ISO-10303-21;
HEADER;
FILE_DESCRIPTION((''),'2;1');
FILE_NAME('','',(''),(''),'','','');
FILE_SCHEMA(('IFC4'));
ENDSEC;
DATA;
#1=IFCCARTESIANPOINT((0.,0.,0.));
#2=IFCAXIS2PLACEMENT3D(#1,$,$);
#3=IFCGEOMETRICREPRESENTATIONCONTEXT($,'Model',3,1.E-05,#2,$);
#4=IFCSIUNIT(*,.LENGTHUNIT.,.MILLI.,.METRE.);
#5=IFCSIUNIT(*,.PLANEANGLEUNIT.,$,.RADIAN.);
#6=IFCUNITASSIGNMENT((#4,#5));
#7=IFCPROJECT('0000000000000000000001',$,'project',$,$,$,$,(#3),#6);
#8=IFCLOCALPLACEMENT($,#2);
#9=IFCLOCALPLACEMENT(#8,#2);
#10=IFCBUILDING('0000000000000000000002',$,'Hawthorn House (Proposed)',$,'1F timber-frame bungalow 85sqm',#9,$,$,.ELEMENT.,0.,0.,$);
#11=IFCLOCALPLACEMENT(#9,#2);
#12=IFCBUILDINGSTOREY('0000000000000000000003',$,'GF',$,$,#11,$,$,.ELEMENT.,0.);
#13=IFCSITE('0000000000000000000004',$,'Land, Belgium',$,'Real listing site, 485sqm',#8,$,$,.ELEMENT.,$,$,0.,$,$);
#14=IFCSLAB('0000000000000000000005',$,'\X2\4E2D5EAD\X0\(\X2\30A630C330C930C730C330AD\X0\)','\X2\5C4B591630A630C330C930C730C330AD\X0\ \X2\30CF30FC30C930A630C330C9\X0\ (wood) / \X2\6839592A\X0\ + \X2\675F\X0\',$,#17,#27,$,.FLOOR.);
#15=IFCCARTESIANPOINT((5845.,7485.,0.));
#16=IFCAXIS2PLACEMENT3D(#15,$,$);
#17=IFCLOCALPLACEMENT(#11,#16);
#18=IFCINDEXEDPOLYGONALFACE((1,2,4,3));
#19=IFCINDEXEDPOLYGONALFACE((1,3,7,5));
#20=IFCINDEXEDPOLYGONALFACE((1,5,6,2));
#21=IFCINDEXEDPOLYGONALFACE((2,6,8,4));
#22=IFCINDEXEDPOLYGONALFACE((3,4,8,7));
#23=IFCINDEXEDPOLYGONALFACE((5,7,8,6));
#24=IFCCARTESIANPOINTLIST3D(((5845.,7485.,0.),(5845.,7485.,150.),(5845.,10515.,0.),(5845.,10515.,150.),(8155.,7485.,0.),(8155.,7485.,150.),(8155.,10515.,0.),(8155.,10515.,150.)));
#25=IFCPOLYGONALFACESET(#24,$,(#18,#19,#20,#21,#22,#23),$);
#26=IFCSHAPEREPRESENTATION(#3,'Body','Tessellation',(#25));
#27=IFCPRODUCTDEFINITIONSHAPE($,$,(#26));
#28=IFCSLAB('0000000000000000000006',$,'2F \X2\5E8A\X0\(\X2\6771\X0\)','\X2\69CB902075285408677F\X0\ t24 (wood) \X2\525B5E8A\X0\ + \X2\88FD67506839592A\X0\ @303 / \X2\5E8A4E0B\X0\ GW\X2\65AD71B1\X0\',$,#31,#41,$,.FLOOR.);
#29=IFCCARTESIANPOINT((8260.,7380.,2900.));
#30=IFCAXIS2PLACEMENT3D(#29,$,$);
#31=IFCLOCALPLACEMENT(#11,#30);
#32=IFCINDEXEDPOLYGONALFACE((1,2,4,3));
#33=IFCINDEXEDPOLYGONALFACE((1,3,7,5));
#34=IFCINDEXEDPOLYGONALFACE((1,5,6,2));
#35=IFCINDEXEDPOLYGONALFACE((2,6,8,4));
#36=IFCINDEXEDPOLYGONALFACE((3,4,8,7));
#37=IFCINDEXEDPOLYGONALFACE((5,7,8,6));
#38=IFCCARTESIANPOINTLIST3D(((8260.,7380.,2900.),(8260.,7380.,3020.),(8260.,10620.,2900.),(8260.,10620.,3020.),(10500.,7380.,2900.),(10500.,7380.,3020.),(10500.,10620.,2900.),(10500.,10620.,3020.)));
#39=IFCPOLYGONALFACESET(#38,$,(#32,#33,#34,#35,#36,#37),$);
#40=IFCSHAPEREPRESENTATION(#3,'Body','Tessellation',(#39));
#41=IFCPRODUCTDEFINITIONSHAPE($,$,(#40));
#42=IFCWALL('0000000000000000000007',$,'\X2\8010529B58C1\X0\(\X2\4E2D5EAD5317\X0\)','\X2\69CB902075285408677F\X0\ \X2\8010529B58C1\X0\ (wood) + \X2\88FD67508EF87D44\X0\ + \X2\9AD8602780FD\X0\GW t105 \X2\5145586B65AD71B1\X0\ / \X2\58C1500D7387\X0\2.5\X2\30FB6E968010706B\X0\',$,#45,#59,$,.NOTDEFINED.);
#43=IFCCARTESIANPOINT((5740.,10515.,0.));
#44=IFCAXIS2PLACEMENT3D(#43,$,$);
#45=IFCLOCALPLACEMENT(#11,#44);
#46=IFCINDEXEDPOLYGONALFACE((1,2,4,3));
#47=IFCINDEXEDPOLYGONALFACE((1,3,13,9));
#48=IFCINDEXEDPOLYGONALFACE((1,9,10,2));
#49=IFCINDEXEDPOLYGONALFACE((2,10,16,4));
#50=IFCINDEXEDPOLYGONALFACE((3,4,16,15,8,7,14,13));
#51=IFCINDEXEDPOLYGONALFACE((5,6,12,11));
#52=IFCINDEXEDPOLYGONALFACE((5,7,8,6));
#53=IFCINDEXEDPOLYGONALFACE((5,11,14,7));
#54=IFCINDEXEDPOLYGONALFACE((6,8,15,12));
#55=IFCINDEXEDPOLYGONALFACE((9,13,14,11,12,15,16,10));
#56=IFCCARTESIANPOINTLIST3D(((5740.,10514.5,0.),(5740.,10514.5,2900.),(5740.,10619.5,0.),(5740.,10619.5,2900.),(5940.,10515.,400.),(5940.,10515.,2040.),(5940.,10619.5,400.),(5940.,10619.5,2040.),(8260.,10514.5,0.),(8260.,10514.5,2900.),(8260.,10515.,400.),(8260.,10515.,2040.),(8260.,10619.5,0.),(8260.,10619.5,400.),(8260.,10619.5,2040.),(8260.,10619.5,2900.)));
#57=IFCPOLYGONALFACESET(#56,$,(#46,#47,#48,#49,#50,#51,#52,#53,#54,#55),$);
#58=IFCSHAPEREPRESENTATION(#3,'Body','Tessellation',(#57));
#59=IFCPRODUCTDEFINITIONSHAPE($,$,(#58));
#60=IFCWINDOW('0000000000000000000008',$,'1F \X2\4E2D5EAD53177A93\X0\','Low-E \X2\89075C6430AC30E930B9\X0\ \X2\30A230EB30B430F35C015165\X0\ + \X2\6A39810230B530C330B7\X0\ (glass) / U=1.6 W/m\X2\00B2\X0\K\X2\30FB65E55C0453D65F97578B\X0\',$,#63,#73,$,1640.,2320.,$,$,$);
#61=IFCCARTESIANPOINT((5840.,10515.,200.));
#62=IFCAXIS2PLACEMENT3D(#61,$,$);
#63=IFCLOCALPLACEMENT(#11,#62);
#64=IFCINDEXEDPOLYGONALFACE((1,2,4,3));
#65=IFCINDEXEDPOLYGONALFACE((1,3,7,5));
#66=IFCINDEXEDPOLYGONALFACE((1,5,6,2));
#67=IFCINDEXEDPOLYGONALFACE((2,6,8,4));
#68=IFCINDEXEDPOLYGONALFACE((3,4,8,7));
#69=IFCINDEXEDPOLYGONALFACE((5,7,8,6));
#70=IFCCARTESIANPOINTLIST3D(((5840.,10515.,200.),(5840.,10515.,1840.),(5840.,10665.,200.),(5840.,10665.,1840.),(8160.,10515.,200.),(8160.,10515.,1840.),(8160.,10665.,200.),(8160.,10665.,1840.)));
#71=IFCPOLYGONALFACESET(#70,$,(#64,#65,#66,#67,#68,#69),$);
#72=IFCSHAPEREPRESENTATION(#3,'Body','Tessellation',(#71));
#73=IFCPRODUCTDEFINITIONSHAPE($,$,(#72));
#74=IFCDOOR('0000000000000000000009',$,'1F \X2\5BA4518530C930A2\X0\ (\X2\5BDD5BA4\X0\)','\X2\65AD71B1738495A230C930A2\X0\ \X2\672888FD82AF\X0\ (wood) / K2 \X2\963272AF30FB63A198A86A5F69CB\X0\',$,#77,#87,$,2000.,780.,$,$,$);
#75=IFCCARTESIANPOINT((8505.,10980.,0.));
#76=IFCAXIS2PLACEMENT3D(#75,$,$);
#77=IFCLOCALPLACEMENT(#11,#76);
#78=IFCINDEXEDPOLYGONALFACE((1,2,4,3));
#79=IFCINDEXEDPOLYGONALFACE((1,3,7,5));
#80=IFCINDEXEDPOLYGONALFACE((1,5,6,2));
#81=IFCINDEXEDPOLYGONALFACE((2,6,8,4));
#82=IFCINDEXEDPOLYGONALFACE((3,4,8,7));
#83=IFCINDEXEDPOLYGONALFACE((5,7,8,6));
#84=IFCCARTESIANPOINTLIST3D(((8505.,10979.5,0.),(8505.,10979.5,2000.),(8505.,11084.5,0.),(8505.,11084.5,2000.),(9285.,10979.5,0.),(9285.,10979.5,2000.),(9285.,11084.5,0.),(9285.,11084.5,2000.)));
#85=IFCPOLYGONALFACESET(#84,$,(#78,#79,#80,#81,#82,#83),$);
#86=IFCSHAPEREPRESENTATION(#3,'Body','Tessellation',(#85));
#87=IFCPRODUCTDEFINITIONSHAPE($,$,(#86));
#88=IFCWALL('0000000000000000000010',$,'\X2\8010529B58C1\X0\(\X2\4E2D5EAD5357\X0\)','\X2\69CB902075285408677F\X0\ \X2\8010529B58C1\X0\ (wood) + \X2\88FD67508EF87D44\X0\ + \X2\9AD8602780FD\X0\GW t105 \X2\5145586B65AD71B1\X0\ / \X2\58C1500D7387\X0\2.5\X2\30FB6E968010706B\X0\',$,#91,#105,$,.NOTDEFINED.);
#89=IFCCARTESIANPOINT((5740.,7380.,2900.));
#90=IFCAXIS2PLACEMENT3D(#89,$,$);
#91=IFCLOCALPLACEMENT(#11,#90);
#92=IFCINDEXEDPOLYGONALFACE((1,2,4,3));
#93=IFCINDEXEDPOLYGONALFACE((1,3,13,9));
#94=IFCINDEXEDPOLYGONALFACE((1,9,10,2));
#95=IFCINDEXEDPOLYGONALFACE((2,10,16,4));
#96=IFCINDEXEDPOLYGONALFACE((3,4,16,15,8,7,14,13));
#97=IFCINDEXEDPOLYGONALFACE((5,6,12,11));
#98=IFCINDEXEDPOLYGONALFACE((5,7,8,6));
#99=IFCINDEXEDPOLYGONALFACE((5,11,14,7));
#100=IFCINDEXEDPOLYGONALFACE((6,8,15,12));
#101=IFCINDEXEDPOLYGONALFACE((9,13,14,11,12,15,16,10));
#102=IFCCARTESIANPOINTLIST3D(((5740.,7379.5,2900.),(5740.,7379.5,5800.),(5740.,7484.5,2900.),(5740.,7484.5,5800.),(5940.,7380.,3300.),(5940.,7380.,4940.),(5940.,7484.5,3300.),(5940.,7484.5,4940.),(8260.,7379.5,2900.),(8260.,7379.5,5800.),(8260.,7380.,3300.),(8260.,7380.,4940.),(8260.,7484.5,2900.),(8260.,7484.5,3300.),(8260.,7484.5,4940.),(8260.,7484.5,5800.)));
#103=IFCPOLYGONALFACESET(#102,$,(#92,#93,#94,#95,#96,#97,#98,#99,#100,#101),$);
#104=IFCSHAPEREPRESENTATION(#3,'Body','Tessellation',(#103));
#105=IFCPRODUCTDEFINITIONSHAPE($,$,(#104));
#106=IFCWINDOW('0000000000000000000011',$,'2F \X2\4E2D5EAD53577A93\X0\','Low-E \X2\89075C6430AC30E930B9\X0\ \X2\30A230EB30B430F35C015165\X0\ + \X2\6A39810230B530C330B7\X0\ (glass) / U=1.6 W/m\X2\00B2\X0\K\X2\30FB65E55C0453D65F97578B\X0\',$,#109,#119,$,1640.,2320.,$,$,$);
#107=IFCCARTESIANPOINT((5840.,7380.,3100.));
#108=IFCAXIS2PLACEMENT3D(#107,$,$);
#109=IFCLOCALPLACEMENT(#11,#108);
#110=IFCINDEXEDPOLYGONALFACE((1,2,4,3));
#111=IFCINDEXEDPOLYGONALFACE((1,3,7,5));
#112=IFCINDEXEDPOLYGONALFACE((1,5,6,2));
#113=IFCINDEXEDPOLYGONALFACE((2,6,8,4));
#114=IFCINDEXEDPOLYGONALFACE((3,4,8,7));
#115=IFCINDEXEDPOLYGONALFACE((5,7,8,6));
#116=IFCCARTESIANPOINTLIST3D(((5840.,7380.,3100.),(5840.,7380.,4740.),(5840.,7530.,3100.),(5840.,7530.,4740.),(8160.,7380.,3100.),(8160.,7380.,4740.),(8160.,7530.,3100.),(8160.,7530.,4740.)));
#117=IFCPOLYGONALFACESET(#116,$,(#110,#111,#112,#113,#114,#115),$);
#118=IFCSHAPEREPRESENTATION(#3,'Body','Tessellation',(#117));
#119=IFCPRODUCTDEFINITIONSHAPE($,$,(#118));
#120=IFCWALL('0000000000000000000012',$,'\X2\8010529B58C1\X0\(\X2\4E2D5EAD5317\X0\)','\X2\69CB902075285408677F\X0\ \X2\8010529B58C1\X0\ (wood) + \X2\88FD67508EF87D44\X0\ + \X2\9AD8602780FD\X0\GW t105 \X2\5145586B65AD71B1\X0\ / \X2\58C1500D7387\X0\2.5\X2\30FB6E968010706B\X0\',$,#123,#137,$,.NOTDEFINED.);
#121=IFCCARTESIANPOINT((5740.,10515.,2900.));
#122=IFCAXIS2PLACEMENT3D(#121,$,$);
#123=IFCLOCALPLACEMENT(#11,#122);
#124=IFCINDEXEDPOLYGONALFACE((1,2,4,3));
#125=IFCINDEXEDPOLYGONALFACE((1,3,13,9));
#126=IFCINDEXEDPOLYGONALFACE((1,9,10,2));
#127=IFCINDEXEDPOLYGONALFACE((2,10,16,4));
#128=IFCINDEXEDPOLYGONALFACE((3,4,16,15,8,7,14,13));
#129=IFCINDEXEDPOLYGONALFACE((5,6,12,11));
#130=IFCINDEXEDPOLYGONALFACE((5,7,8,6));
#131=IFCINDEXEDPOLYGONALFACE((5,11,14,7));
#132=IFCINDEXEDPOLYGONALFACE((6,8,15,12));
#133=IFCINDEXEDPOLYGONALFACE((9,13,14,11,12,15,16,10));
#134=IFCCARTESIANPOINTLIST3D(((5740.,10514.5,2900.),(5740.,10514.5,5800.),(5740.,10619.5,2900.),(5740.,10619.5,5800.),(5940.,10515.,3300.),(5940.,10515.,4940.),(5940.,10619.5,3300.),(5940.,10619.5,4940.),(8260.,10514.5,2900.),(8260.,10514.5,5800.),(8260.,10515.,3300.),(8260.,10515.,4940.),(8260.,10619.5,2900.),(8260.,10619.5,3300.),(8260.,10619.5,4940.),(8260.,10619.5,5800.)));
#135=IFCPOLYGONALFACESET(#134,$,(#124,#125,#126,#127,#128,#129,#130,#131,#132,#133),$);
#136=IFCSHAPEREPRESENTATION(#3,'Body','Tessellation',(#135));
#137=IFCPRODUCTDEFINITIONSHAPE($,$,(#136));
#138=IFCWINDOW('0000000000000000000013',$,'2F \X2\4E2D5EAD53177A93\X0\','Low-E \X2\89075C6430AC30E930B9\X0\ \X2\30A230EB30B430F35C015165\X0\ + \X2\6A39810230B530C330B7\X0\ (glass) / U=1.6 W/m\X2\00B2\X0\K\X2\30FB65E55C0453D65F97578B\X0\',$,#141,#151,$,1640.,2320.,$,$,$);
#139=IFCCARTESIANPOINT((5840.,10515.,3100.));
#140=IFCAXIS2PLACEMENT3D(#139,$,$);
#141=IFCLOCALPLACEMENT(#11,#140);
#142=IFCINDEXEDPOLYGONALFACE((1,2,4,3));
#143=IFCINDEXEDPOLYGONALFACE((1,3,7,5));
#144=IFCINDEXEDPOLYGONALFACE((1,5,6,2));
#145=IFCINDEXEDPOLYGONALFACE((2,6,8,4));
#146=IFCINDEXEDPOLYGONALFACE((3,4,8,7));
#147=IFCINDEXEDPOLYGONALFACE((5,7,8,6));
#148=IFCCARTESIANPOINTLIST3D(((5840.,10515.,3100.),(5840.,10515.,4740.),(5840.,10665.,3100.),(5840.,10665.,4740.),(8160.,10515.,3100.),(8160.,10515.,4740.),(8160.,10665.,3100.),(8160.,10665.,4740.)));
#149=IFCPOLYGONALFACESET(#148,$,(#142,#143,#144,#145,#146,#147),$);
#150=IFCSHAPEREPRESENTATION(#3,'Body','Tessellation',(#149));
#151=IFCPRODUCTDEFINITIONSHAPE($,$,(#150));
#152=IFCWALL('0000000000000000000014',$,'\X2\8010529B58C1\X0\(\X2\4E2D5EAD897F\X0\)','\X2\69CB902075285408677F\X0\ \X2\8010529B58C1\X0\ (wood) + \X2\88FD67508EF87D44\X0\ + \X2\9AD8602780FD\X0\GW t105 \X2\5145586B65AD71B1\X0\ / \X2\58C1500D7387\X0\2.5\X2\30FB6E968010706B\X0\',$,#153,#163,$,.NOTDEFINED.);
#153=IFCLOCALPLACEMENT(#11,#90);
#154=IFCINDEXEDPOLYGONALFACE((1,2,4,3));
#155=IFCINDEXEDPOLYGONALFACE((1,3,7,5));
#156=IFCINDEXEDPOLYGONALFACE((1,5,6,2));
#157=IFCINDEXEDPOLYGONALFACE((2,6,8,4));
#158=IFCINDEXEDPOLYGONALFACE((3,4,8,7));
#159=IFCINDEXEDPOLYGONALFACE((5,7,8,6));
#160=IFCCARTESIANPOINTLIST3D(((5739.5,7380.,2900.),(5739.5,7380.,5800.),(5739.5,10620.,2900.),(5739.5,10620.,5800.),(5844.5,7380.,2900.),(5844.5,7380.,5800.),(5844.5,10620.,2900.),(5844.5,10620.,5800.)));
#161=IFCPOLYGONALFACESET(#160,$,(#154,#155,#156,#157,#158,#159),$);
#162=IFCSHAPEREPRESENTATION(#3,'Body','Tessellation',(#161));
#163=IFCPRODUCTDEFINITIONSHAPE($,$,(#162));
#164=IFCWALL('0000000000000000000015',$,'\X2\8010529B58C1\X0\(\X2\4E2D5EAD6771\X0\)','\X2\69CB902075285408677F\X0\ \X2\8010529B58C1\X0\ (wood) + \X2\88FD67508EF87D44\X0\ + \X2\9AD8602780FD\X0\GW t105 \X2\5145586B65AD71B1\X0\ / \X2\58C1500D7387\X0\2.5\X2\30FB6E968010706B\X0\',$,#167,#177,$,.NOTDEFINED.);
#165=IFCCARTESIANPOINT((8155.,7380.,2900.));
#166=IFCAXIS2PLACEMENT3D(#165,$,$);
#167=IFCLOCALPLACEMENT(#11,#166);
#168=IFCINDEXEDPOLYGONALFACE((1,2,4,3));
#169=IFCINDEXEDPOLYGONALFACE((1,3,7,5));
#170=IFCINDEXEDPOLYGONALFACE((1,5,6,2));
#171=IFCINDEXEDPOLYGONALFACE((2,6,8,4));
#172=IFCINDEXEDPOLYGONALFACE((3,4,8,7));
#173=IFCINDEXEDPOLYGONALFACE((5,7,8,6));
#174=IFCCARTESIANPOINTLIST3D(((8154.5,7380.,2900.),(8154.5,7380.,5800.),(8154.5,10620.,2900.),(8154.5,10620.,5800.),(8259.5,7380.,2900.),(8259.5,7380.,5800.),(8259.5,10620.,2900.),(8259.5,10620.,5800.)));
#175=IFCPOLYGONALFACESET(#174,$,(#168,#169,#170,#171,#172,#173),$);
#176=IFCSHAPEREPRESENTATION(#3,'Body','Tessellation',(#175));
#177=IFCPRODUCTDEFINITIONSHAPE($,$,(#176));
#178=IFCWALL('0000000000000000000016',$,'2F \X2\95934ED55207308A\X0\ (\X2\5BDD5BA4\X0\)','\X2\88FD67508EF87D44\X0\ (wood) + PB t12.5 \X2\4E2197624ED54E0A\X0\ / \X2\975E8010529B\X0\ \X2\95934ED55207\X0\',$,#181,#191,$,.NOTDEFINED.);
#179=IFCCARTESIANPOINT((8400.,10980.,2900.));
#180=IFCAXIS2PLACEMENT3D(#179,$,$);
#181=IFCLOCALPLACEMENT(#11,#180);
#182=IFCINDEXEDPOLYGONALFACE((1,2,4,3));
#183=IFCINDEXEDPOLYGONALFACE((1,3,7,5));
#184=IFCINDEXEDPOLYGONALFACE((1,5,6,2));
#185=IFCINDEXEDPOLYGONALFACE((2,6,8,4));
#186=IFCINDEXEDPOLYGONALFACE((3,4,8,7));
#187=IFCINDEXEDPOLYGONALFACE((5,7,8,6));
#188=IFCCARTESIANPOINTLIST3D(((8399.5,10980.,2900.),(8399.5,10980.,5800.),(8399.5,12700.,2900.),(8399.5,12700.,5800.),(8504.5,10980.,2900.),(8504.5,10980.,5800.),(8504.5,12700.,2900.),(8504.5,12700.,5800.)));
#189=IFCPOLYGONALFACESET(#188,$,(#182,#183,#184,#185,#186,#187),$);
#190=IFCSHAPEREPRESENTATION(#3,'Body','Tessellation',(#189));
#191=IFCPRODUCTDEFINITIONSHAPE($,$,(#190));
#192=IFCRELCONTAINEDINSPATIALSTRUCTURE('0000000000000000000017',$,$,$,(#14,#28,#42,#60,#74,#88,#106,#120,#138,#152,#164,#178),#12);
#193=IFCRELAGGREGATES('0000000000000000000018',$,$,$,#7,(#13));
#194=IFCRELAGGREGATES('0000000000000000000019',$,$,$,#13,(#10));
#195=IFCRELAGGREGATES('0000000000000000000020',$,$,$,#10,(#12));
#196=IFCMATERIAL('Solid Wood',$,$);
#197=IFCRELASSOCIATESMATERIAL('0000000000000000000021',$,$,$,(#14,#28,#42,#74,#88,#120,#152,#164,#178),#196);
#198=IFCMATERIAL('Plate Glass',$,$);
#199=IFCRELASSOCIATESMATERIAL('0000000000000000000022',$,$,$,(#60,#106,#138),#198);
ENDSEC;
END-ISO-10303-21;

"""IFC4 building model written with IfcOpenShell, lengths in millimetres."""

from ifc_helpers import new_model, si_unit, frame, frame_2d, origin, place, context, project, spatial, rectangle, extrude, material, element, fill, save


model = new_model("IFC4")

# Units and contexts
model_context = context("Model", 3, precision=1e-05, world=origin())
ifc_project = project(units=[si_unit("LENGTHUNIT", "METRE", prefix="MILLI"), si_unit("PLANEANGLEUNIT", "RADIAN")], contexts=[model_context])

# Site, building, storey
site_placement = place(None, origin())
site = spatial("IfcSite", under=ifc_project, at=site_placement, Name="Land, Belgium", ObjectType="Real listing site, 485sqm", CompositionType="ELEMENT", RefElevation=0.0)
building_placement = place(site_placement, origin())
building = spatial("IfcBuilding", under=site, at=building_placement, Name="Hawthorn House (Proposed)", ObjectType="1F timber-frame bungalow 85sqm", CompositionType="ELEMENT", ElevationOfRefHeight=0.0, ElevationOfTerrain=0.0)
storey_placement = place(building_placement, origin())
storey = spatial("IfcBuildingStorey", under=building, at=storey_placement, Name="GF", CompositionType="ELEMENT", Elevation=0.0)

# Slabs
ifc_material_1 = material(Name="Solid Wood")
slab_1_placement = place(storey_placement, frame((5845.0, 7485.0, 0.0)))
element("IfcSlab", 1, at=slab_1_placement, inside=storey, material=ifc_material_1, Name="中庭(ウッドデッキ)", Description="屋外ウッドデッキ ハードウッド (wood) / 根太 + 束", PredefinedType="FLOOR", context=model_context, shape_type="SweptSolid", body=[
    extrude(rectangle(XDim=2310.0, YDim=3030.0, at=frame_2d((1155.0, 1515.0))), frame((5845.0, 7485.0, 0.0)), (0.0, 0.0, 1.0), 150.0),
])
slab_2_placement = place(storey_placement, frame((8260.0, 7380.0, 2900.0)))
element("IfcSlab", 2, at=slab_2_placement, inside=storey, material=ifc_material_1, Name="2F 床(東)", Description="構造用合板 t24 (wood) 剛床 + 製材根太 @303 / 床下 GW断熱", PredefinedType="FLOOR", context=model_context, shape_type="SweptSolid", body=[
    extrude(rectangle(XDim=2240.0, YDim=3240.0, at=frame_2d((1120.0, 1620.0))), frame((8260.0, 7380.0, 2900.0)), (0.0, 0.0, 1.0), 120.0),
])

# Wall, opening, window
wall_1_placement = place(storey_placement, frame((5740.0, 10515.0, 0.0)))
wall_1 = element("IfcWall", 3, at=wall_1_placement, inside=storey, material=ifc_material_1, Name="耐力壁(中庭北)", Description="構造用合板 耐力壁 (wood) + 製材軸組 + 高性能GW t105 充填断熱 / 壁倍率2.5・準耐火", PredefinedType="NOTDEFINED", context=model_context, shape_type="SweptSolid", body=[
    extrude(rectangle(XDim=2520.0, YDim=105.0, at=frame_2d((1260.0, 52.0))), frame((5740.0, 10515.0, 0.0)), (0.0, 0.0, 1.0), 2900.0),
])
opening_1_placement = place(storey_placement, frame((5840.0, 10515.0, 200.0)))
opening_1 = element("IfcOpeningElement", 4, at=opening_1_placement, cuts=wall_1, PredefinedType="NOTDEFINED", context=model_context, shape_type="SweptSolid", body=[
    extrude(rectangle(XDim=2320.0, YDim=150.0, at=frame_2d((1160.0, 75.0))), frame((5840.0, 10515.0, 200.0)), (0.0, 0.0, 1.0), 1640.0),
])
ifc_material_2 = material(Name="Plate Glass")
window_1_placement = place(storey_placement, frame((5840.0, 10515.0, 200.0)))
window_1 = element("IfcWindow", 5, at=window_1_placement, inside=storey, material=ifc_material_2, Name="1F 中庭北窓", Description="Low-E 複層ガラス アルゴン封入 + 樹脂サッシ (glass) / U=1.6 W/m²K・日射取得型", OverallHeight=1640.0, OverallWidth=2320.0, context=model_context, shape_type="SweptSolid", body=[
    extrude(rectangle(XDim=2320.0, YDim=150.0, at=frame_2d((1160.0, 75.0))), frame((5840.0, 10515.0, 200.0)), (0.0, 0.0, 1.0), 1640.0),
])
fill(opening_1, window_1)

# Door
door_1_placement = place(storey_placement, frame((8505.0, 10980.0, 0.0)))
element("IfcDoor", 6, at=door_1_placement, inside=storey, material=ifc_material_1, Name="1F 室内ドア (寝室)", Description="断熱玄関ドア 木製芯 (wood) / K2 防犯・採風機構", OverallHeight=2000.0, OverallWidth=780.0, context=model_context, shape_type="SweptSolid", body=[
    extrude(rectangle(XDim=780.0, YDim=105.0, at=frame_2d((390.0, 52.0))), frame((8505.0, 10980.0, 0.0)), (0.0, 0.0, 1.0), 2000.0),
])

# Walls, openings, windows
wall_2_placement = place(storey_placement, frame((5740.0, 7380.0, 2900.0)))
wall_2 = element("IfcWall", 7, at=wall_2_placement, inside=storey, material=ifc_material_1, Name="耐力壁(中庭南)", Description="構造用合板 耐力壁 (wood) + 製材軸組 + 高性能GW t105 充填断熱 / 壁倍率2.5・準耐火", PredefinedType="NOTDEFINED", context=model_context, shape_type="SweptSolid", body=[
    extrude(rectangle(XDim=2520.0, YDim=105.0, at=frame_2d((1260.0, 52.0))), frame((5740.0, 7380.0, 2900.0)), (0.0, 0.0, 1.0), 2900.0),
])
opening_2_placement = place(storey_placement, frame((5840.0, 7380.0, 3100.0)))
opening_2 = element("IfcOpeningElement", 8, at=opening_2_placement, cuts=wall_2, PredefinedType="NOTDEFINED", context=model_context, shape_type="SweptSolid", body=[
    extrude(rectangle(XDim=2320.0, YDim=150.0, at=frame_2d((1160.0, 75.0))), frame((5840.0, 7380.0, 3100.0)), (0.0, 0.0, 1.0), 1640.0),
])
window_2_placement = place(storey_placement, frame((5840.0, 7380.0, 3100.0)))
window_2 = element("IfcWindow", 9, at=window_2_placement, inside=storey, material=ifc_material_2, Name="2F 中庭南窓", Description="Low-E 複層ガラス アルゴン封入 + 樹脂サッシ (glass) / U=1.6 W/m²K・日射取得型", OverallHeight=1640.0, OverallWidth=2320.0, context=model_context, shape_type="SweptSolid", body=[
    extrude(rectangle(XDim=2320.0, YDim=150.0, at=frame_2d((1160.0, 75.0))), frame((5840.0, 7380.0, 3100.0)), (0.0, 0.0, 1.0), 1640.0),
])
fill(opening_2, window_2)
wall_3_placement = place(storey_placement, frame((5740.0, 10515.0, 2900.0)))
wall_3 = element("IfcWall", 10, at=wall_3_placement, inside=storey, material=ifc_material_1, Name="耐力壁(中庭北)", Description="構造用合板 耐力壁 (wood) + 製材軸組 + 高性能GW t105 充填断熱 / 壁倍率2.5・準耐火", PredefinedType="NOTDEFINED", context=model_context, shape_type="SweptSolid", body=[
    extrude(rectangle(XDim=2520.0, YDim=105.0, at=frame_2d((1260.0, 52.0))), frame((5740.0, 10515.0, 2900.0)), (0.0, 0.0, 1.0), 2900.0),
])
opening_3_placement = place(storey_placement, frame((5840.0, 10515.0, 3100.0)))
opening_3 = element("IfcOpeningElement", 11, at=opening_3_placement, cuts=wall_3, PredefinedType="NOTDEFINED", context=model_context, shape_type="SweptSolid", body=[
    extrude(rectangle(XDim=2320.0, YDim=150.0, at=frame_2d((1160.0, 75.0))), frame((5840.0, 10515.0, 3100.0)), (0.0, 0.0, 1.0), 1640.0),
])
window_3_placement = place(storey_placement, frame((5840.0, 10515.0, 3100.0)))
window_3 = element("IfcWindow", 12, at=window_3_placement, inside=storey, material=ifc_material_2, Name="2F 中庭北窓", Description="Low-E 複層ガラス アルゴン封入 + 樹脂サッシ (glass) / U=1.6 W/m²K・日射取得型", OverallHeight=1640.0, OverallWidth=2320.0, context=model_context, shape_type="SweptSolid", body=[
    extrude(rectangle(XDim=2320.0, YDim=150.0, at=frame_2d((1160.0, 75.0))), frame((5840.0, 10515.0, 3100.0)), (0.0, 0.0, 1.0), 1640.0),
])
fill(opening_3, window_3)

# Walls
wall_4_placement = place(storey_placement, frame((5740.0, 7380.0, 2900.0)))
element("IfcWall", 13, at=wall_4_placement, inside=storey, material=ifc_material_1, Name="耐力壁(中庭西)", Description="構造用合板 耐力壁 (wood) + 製材軸組 + 高性能GW t105 充填断熱 / 壁倍率2.5・準耐火", PredefinedType="NOTDEFINED", context=model_context, shape_type="SweptSolid", body=[
    extrude(rectangle(XDim=105.0, YDim=3240.0, at=frame_2d((52.0, 1620.0))), frame((5740.0, 7380.0, 2900.0)), (0.0, 0.0, 1.0), 2900.0),
])
wall_5_placement = place(storey_placement, frame((8155.0, 7380.0, 2900.0)))
element("IfcWall", 14, at=wall_5_placement, inside=storey, material=ifc_material_1, Name="耐力壁(中庭東)", Description="構造用合板 耐力壁 (wood) + 製材軸組 + 高性能GW t105 充填断熱 / 壁倍率2.5・準耐火", PredefinedType="NOTDEFINED", context=model_context, shape_type="SweptSolid", body=[
    extrude(rectangle(XDim=105.0, YDim=3240.0, at=frame_2d((52.0, 1620.0))), frame((8155.0, 7380.0, 2900.0)), (0.0, 0.0, 1.0), 2900.0),
])
wall_6_placement = place(storey_placement, frame((8400.0, 10980.0, 2900.0)))
element("IfcWall", 15, at=wall_6_placement, inside=storey, material=ifc_material_1, Name="2F 間仕切り (寝室)", Description="製材軸組 (wood) + PB t12.5 両面仕上 / 非耐力 間仕切", PredefinedType="NOTDEFINED", context=model_context, shape_type="SweptSolid", body=[
    extrude(rectangle(XDim=105.0, YDim=1720.0, at=frame_2d((52.0, 860.0))), frame((8400.0, 10980.0, 2900.0)), (0.0, 0.0, 1.0), 2900.0),
])

save(model, "model.ifc")
